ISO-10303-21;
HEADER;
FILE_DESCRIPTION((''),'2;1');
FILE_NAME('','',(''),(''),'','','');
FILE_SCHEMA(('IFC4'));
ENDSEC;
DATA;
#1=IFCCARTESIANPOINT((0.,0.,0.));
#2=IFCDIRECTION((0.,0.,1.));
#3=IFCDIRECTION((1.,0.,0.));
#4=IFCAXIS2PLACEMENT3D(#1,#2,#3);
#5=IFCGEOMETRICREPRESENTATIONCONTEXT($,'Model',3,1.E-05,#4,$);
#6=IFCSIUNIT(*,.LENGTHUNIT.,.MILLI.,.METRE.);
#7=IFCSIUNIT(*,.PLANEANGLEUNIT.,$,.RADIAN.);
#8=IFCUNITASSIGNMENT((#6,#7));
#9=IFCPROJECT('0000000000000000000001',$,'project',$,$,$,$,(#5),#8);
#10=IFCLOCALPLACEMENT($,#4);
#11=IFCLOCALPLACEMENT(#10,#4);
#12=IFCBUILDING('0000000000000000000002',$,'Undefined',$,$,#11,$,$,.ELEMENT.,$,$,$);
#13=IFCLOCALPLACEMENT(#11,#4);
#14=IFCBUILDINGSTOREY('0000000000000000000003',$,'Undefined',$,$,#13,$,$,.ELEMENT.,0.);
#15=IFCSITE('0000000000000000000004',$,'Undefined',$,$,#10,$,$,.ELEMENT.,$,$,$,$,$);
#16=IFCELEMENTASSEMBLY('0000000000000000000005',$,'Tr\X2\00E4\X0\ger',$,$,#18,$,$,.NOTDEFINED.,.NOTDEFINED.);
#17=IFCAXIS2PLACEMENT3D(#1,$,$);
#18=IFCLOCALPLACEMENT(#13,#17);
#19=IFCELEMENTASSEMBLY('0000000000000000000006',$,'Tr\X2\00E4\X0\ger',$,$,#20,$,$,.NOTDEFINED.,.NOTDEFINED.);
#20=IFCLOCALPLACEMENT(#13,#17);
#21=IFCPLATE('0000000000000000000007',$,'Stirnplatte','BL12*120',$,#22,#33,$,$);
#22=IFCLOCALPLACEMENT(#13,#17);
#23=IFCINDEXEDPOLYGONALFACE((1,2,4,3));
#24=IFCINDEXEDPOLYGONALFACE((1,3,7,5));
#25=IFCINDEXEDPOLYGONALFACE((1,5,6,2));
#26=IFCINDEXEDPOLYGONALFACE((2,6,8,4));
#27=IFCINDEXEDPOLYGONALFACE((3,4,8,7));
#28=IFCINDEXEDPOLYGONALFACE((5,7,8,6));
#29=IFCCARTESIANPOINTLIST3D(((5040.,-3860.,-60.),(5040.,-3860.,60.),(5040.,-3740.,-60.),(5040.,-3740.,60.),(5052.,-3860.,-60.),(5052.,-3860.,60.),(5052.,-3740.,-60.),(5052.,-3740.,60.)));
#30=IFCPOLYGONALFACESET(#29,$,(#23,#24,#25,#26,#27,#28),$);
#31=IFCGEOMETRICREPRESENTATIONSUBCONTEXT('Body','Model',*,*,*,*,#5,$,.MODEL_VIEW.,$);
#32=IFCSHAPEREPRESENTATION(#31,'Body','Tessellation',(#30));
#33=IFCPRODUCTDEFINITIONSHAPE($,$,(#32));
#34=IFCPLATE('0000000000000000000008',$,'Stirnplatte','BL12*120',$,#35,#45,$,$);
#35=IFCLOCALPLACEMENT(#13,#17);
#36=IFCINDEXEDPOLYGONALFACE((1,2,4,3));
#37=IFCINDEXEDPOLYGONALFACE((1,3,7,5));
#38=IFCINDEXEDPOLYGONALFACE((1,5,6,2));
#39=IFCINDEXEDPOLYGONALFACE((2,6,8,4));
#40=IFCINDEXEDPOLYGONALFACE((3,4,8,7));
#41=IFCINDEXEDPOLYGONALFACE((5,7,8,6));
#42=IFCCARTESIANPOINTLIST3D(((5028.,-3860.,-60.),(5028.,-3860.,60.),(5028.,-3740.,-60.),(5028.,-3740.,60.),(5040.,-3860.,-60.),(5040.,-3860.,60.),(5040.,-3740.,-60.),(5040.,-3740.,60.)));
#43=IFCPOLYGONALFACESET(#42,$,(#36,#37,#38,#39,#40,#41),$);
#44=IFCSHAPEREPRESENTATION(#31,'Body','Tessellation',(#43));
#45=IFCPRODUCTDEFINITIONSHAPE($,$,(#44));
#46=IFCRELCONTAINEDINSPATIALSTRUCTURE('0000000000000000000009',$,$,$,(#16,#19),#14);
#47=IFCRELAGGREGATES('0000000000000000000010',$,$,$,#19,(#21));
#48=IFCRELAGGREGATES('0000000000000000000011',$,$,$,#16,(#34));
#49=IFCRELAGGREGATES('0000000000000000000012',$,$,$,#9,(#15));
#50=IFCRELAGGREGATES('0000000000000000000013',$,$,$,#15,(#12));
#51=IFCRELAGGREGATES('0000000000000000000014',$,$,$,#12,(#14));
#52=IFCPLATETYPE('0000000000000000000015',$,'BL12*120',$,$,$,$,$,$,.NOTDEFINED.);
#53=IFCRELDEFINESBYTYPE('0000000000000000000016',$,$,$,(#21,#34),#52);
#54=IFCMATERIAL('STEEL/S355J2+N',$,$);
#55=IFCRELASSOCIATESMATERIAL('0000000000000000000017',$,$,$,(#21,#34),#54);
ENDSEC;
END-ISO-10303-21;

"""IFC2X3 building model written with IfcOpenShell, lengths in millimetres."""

from ifc_helpers import new_model, si_unit, frame, origin_with_axes, place, context, subcontext, project, spatial, polyline, outline, extrude, material, type_object, element, aggregate, save


model = new_model("IFC2X3")

# Units and contexts
model_context = context("Model", 3, precision=1e-05, world=origin_with_axes())
body_context = subcontext(model_context, "Body", "Model", "MODEL_VIEW")
ifc_project = project(units=[si_unit("LENGTHUNIT", "METRE", prefix="MILLI"), si_unit("PLANEANGLEUNIT", "RADIAN")], contexts=[model_context])

# Site, building, storey
site_placement = place(None, origin_with_axes())
site = spatial("IfcSite", under=ifc_project, at=site_placement, Name="Undefined", CompositionType="ELEMENT")
building_placement = place(site_placement, origin_with_axes())
building = spatial("IfcBuilding", under=site, at=building_placement, Name="Undefined", CompositionType="ELEMENT")
storey_placement = place(building_placement, origin_with_axes())
storey = spatial("IfcBuildingStorey", under=building, at=storey_placement, Name="Undefined", CompositionType="ELEMENT", Elevation=0.0)

# Element assembly
assembly_1_placement = place(storey_placement, origin_with_axes())
assembly_1 = element("IfcElementAssembly", 1, at=assembly_1_placement, inside=storey, Name="Träger", AssemblyPlace="NOTDEFINED", PredefinedType="NOTDEFINED")

# Element assembly
assembly_2_placement = place(storey_placement, origin_with_axes())
assembly_2 = element("IfcElementAssembly", 2, at=assembly_2_placement, inside=storey, Name="Träger", AssemblyPlace="NOTDEFINED", PredefinedType="NOTDEFINED")

# Plates
ifc_material_1 = material(Name="STEEL/S355J2+N")
plate_type_1 = type_object("IfcPlateType", Name="BL12*120", PredefinedType="NOTDEFINED")
plate_1_placement = place(assembly_2_placement, frame((5046.0, -3800.0, -60.0), z_axis=(1.0, 0.0, 0.0), x_axis=(0.0, 0.0, 1.0)))
plate_1 = element("IfcPlate", 3, at=plate_1_placement, type_object=plate_type_1, material=ifc_material_1, Name="Stirnplatte", Description="BL12*120", context=body_context, shape_type="SweptSolid", body=[
    extrude(outline(polyline([(0.0, -60.0), (0.0, 60.0), (120.0, 60.0), (120.0, -60.0), (0.0, -60.0)])), frame((0.0, 0.0, -6.0), z_axis=(0.0, 0.0, 1.0), x_axis=(1.0, 0.0, 0.0)), (0.0, 0.0, 1.0), 12.0),
])
aggregate(assembly_2, [plate_1])
plate_2_placement = place(assembly_1_placement, frame((5034.0, -3800.0, -60.0), z_axis=(1.0, 0.0, 0.0), x_axis=(0.0, 0.0, 1.0)))
plate_2 = element("IfcPlate", 4, at=plate_2_placement, type_object=plate_type_1, material=ifc_material_1, Name="Stirnplatte", Description="BL12*120", context=body_context, shape_type="SweptSolid", body=[
    extrude(outline(polyline([(0.0, -60.0), (0.0, 60.0), (120.0, 60.0), (120.0, -60.0), (0.0, -60.0)])), frame((0.0, 0.0, -6.0), z_axis=(0.0, 0.0, 1.0), x_axis=(1.0, 0.0, 0.0)), (0.0, 0.0, 1.0), 12.0),
])
aggregate(assembly_1, [plate_2])

save(model, "model.ifc")
